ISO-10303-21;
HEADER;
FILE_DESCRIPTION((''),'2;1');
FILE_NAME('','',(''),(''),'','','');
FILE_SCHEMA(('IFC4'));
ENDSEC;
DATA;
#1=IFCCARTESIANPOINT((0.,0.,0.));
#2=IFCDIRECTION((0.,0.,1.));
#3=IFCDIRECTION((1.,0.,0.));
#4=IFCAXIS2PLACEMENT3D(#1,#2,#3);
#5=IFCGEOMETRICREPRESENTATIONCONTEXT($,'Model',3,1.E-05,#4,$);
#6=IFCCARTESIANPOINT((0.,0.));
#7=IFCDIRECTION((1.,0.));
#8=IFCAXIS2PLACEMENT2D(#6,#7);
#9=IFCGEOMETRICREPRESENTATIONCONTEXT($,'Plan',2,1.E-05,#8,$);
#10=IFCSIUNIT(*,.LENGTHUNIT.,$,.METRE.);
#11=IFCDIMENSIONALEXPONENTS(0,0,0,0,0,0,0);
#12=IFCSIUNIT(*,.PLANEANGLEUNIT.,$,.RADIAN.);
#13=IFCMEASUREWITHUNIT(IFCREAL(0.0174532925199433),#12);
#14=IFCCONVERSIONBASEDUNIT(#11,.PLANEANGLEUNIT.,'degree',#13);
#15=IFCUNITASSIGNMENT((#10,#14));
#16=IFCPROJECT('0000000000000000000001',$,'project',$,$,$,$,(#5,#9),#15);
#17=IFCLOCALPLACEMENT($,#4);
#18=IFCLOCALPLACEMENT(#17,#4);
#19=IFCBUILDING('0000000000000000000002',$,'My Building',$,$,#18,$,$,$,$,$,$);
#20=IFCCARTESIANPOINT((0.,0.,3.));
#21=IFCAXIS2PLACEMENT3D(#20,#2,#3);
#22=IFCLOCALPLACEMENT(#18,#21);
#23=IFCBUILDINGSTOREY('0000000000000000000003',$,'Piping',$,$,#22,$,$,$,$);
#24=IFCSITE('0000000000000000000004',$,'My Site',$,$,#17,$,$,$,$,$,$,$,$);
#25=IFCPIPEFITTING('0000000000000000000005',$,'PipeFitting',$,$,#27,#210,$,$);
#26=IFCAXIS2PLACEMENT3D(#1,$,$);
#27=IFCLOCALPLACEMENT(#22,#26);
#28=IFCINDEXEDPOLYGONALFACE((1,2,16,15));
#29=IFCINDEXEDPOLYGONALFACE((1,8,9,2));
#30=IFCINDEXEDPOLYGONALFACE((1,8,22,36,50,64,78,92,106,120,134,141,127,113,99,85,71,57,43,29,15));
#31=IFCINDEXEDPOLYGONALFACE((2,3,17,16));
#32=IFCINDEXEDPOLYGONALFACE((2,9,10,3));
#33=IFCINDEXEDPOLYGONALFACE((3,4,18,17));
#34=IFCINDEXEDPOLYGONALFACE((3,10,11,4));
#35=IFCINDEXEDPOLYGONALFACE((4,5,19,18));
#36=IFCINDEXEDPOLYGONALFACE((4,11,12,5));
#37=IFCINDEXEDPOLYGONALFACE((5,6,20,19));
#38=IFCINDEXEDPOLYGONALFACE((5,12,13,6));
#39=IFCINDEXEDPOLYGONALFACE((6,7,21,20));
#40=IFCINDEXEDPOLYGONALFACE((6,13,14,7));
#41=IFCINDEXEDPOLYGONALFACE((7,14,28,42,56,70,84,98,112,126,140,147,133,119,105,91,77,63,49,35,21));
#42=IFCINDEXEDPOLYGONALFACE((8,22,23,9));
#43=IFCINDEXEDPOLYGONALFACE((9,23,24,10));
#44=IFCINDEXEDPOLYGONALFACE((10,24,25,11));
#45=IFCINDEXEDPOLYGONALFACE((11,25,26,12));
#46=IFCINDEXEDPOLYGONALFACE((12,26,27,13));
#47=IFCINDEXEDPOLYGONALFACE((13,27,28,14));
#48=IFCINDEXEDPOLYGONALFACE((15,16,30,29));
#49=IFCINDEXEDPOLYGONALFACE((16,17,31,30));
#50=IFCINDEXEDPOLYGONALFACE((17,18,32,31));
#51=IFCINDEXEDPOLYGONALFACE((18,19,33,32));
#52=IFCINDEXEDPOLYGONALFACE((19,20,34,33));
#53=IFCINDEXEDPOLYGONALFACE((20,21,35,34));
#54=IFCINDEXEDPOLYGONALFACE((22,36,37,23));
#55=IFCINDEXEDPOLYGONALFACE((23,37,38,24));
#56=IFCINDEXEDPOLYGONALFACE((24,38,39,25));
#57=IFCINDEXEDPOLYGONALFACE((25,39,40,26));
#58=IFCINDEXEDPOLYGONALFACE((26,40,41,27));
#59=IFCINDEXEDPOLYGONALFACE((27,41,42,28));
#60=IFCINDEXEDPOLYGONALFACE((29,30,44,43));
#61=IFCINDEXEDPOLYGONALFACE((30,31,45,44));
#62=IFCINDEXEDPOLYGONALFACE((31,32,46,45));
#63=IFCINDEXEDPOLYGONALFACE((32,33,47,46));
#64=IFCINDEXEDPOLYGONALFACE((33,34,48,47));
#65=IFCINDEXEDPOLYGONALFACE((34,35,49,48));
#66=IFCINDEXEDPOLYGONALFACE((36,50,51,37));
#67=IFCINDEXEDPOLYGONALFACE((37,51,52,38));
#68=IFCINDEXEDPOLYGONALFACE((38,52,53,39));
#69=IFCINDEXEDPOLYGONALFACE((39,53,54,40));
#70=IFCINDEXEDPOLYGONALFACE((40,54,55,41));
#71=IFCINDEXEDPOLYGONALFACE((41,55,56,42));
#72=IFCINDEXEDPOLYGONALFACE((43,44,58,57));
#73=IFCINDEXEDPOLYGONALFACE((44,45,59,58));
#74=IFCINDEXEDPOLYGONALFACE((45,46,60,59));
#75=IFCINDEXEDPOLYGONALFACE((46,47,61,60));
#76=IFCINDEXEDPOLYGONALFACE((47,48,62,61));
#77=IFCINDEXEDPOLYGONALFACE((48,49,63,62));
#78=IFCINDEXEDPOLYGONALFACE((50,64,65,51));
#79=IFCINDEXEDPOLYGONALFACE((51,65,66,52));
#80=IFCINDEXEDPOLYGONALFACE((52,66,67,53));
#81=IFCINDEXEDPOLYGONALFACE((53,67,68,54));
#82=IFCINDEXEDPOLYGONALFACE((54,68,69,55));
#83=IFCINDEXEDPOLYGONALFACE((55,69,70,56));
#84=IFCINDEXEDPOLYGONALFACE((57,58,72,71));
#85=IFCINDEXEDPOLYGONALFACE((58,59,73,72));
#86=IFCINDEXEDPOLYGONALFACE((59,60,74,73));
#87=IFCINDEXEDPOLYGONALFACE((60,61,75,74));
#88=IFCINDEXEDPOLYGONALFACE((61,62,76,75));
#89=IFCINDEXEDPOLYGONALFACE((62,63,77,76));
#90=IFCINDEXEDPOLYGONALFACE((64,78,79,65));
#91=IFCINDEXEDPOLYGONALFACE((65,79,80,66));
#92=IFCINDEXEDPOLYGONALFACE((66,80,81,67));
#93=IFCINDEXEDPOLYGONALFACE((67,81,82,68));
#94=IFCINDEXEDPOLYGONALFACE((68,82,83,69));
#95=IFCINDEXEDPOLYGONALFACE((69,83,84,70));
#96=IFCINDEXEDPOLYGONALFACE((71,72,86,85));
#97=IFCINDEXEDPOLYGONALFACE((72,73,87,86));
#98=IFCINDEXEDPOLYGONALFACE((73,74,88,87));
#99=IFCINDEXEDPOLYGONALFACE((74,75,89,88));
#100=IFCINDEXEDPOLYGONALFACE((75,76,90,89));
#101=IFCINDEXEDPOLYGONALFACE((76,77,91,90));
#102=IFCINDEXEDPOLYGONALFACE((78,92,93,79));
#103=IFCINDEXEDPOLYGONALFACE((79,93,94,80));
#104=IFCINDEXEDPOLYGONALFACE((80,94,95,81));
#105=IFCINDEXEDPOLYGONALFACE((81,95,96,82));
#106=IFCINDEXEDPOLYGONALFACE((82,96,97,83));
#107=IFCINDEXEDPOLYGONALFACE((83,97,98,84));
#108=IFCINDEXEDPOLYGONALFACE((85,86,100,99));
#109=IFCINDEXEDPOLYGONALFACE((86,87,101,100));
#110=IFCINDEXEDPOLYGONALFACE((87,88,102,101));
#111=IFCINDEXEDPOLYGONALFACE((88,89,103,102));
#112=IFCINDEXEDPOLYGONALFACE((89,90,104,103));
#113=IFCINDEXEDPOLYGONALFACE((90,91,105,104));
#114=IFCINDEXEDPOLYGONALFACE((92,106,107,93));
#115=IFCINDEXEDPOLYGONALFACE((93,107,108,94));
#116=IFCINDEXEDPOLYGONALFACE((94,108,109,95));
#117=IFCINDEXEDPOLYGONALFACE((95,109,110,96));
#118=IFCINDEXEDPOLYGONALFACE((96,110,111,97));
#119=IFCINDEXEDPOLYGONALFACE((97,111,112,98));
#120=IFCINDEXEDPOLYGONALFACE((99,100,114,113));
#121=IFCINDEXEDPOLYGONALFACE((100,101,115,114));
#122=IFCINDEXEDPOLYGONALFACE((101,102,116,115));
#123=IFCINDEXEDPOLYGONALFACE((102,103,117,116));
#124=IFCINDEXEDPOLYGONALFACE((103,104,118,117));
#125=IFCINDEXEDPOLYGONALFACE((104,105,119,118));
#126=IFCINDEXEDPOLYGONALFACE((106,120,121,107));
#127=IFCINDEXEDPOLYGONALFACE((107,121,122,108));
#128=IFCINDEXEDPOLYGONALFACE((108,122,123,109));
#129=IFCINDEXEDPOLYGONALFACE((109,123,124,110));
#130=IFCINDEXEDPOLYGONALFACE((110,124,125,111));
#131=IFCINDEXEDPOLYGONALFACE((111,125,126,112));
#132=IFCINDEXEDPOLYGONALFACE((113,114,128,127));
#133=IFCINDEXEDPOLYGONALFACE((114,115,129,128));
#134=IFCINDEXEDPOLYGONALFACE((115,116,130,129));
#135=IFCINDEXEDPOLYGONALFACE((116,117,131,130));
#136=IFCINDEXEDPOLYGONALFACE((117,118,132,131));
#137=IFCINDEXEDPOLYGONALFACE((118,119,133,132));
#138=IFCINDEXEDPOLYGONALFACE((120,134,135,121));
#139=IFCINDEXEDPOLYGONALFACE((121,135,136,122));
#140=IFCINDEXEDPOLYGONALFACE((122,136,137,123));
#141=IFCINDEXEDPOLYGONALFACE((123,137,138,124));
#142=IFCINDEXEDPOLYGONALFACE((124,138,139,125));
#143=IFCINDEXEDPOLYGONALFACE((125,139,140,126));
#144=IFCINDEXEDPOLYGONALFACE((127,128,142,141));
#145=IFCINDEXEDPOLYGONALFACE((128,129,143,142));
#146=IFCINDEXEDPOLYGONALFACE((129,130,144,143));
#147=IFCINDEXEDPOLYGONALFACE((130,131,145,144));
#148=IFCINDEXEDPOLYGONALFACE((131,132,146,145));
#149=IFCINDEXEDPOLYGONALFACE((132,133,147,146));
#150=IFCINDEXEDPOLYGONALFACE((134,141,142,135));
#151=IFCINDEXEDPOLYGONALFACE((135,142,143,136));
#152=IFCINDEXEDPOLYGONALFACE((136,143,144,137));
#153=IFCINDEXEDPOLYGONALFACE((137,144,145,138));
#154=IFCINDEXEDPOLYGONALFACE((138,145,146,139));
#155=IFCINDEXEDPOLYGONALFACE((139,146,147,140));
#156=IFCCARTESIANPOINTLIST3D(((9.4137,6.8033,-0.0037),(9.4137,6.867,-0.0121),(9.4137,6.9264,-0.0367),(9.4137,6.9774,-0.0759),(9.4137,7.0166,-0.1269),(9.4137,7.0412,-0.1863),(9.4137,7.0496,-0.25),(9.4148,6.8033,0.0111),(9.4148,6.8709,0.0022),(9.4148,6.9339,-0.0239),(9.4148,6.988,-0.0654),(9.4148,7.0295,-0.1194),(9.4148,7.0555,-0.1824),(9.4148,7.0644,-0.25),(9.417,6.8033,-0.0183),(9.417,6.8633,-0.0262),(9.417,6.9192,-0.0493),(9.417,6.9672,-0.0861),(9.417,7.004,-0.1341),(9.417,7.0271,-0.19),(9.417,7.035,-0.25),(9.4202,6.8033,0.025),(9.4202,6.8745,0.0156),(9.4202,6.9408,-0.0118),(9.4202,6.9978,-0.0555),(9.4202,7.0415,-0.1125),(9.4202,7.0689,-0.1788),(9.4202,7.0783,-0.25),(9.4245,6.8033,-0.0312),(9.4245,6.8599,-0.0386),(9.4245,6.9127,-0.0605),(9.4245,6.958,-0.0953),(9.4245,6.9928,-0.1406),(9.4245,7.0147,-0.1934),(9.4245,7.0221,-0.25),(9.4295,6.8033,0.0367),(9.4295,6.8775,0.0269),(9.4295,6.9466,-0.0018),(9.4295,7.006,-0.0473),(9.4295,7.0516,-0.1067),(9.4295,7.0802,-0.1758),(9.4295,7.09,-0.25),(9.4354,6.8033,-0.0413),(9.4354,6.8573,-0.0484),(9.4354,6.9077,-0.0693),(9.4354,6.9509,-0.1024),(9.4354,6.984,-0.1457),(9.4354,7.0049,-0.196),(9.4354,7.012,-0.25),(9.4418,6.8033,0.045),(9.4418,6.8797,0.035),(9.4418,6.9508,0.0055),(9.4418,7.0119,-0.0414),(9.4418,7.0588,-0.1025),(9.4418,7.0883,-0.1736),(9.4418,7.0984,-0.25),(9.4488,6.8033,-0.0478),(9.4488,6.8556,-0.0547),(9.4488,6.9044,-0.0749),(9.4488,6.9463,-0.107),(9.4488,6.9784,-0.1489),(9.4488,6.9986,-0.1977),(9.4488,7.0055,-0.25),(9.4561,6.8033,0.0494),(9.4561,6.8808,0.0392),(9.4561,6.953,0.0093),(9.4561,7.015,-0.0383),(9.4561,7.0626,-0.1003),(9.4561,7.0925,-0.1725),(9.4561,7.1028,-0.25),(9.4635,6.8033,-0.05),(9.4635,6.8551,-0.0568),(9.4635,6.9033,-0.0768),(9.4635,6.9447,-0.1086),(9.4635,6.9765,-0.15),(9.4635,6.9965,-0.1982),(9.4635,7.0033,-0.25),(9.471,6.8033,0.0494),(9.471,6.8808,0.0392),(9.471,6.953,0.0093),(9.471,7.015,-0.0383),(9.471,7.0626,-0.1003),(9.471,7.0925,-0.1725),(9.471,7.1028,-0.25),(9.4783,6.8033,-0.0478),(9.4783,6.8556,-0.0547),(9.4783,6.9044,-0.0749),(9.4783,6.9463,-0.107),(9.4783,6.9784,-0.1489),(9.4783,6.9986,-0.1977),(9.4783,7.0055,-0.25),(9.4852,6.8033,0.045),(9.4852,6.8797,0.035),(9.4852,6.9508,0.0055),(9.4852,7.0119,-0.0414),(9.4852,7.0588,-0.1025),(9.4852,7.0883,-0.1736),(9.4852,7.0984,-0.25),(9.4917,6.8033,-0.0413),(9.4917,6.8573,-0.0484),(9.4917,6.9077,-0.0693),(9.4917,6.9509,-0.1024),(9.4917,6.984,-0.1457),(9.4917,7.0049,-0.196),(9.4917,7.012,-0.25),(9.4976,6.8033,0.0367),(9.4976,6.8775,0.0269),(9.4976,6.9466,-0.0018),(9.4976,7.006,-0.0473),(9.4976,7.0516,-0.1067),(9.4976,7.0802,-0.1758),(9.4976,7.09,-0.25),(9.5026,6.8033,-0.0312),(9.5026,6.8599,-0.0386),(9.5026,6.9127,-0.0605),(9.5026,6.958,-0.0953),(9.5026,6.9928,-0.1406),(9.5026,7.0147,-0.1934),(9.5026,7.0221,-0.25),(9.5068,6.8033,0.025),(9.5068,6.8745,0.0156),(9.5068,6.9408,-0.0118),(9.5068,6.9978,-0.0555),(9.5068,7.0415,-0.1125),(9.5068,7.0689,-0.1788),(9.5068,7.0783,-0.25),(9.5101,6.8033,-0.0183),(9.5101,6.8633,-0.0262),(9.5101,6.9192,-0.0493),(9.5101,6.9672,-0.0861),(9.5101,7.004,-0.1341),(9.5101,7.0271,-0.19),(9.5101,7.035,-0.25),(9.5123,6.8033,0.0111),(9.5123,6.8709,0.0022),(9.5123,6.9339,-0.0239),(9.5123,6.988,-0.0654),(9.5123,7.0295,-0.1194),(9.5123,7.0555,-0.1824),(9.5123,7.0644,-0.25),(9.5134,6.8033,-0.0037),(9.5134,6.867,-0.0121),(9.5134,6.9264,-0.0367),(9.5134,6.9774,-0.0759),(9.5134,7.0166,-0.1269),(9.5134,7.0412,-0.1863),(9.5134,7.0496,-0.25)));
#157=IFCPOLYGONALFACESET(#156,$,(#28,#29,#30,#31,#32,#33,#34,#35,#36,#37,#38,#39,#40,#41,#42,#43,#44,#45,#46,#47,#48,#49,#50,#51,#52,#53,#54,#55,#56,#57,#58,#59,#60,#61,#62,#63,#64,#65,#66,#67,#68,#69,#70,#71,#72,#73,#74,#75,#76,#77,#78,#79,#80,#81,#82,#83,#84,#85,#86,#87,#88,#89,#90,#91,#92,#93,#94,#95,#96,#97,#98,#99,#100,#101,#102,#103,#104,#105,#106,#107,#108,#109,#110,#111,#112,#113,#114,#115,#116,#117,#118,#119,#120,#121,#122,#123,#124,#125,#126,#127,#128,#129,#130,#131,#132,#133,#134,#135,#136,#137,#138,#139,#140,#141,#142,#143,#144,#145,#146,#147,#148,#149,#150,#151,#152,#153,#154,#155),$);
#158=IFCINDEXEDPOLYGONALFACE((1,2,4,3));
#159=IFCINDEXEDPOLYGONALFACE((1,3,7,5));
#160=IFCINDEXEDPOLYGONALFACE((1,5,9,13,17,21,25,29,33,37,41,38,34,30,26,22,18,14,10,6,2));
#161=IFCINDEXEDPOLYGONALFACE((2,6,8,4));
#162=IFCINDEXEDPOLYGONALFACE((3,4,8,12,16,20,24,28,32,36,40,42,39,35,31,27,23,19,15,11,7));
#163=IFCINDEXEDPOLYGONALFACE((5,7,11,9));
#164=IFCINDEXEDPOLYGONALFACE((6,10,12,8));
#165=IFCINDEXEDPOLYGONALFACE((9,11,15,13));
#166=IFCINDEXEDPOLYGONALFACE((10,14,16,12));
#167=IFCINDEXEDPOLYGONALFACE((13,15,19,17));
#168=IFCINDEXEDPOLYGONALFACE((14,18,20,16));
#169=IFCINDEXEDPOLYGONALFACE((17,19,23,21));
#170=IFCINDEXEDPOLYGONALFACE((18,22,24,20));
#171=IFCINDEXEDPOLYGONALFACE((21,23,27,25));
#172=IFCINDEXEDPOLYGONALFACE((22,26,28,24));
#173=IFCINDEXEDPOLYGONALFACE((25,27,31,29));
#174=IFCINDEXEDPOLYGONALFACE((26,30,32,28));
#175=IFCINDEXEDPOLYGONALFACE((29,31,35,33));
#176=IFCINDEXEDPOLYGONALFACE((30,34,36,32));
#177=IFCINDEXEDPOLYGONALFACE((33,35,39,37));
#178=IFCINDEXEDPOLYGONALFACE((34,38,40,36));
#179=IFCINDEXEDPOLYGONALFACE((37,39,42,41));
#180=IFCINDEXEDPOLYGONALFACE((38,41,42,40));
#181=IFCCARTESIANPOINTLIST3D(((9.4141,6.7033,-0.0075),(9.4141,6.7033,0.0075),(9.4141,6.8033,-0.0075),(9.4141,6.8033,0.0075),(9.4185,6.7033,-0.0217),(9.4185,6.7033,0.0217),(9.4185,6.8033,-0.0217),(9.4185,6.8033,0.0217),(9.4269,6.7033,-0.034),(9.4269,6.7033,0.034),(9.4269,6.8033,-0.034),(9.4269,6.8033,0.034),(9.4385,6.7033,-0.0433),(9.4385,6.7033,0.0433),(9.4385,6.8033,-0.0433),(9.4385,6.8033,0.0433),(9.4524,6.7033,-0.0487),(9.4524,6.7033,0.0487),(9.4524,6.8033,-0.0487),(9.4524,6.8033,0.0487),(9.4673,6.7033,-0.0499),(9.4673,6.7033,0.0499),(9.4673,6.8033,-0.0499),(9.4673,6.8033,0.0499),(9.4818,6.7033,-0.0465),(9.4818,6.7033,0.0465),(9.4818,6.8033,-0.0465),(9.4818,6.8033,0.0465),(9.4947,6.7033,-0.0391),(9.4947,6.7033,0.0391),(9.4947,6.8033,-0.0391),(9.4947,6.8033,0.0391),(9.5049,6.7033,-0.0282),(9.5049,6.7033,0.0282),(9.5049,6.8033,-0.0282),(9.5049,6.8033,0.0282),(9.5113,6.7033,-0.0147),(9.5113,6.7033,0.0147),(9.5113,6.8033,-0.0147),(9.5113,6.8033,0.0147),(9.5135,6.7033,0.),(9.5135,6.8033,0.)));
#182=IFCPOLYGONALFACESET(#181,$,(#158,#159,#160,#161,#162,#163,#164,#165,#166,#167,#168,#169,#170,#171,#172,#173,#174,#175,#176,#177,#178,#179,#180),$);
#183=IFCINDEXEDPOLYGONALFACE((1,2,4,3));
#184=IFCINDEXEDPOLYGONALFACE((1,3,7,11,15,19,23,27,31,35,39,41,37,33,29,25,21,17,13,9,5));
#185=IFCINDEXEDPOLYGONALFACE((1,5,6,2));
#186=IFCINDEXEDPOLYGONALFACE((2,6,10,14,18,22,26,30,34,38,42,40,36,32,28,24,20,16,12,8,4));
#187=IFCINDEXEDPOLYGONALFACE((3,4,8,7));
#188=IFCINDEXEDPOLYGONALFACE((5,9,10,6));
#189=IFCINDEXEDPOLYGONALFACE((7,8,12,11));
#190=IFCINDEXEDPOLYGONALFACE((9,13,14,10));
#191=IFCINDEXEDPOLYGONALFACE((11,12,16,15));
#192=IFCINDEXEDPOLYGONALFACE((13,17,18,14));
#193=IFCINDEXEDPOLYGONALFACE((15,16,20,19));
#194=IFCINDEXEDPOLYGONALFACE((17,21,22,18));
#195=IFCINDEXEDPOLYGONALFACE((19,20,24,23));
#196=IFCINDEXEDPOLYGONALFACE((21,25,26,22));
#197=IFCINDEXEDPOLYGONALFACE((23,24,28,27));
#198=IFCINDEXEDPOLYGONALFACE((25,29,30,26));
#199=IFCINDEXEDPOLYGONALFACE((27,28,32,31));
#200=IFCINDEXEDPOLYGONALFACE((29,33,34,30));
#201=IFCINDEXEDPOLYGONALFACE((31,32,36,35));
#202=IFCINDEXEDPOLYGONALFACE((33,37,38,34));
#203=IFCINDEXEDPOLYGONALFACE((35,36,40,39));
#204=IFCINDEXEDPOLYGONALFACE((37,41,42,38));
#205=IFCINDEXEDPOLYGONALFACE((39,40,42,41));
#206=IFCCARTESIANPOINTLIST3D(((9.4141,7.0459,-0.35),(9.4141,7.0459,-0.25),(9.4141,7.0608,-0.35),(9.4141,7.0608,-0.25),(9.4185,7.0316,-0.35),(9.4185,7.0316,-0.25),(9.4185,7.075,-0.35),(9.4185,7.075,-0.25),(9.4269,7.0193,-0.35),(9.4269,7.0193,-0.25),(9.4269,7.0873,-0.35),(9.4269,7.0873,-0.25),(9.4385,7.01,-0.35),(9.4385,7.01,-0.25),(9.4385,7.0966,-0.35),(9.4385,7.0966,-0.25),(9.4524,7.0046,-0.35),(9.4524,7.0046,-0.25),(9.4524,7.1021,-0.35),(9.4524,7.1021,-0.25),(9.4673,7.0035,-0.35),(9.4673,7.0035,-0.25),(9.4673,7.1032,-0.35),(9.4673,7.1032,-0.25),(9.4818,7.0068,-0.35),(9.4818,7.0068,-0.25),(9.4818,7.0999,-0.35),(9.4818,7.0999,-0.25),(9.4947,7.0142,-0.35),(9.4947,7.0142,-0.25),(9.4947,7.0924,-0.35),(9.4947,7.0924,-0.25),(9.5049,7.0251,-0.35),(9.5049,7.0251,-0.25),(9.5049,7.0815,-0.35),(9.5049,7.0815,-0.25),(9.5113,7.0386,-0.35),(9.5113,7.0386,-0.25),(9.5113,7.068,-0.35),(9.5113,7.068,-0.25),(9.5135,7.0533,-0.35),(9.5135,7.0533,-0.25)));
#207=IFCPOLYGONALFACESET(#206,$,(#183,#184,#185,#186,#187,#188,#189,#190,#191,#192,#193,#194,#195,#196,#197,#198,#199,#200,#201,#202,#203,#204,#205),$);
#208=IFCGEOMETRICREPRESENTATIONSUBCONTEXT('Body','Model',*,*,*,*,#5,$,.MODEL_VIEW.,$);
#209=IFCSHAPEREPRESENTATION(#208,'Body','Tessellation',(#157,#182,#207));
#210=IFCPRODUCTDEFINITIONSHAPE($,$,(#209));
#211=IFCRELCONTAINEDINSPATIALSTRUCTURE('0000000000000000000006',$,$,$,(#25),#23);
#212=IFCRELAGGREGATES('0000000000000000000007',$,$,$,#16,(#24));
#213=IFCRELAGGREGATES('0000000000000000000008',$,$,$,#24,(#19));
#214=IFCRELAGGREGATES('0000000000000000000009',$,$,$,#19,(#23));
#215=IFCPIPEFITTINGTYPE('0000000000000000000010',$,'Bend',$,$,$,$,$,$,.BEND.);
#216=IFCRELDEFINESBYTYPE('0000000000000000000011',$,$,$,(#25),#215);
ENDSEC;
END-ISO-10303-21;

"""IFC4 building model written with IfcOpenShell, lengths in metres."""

from ifc_helpers import new_model, entity, si_unit, converted_unit, frame, origin_with_axes, origin_2d_with_axis, place, context, subcontext, project, spatial, circle, extrude, source, transform, mapped, type_object, type_shapes, element, save


model = new_model("IFC4")

# Units and contexts
model_context = context("Model", 3, precision=1e-05, world=origin_with_axes())
plan_context = context("Plan", 2, precision=1e-05, world=origin_2d_with_axis())
body_context = subcontext(model_context, "Body", "Model", "MODEL_VIEW")
ifc_project = project(units=[si_unit("LENGTHUNIT", "METRE"), converted_unit("PLANEANGLEUNIT", "degree", entity("IfcReal", 0.0174532925199433), si_unit("PLANEANGLEUNIT", "RADIAN"), dimensions=[0, 0, 0, 0, 0, 0, 0])], contexts=[model_context, plan_context])

# Site, building, storey
site_placement = place(None, origin_with_axes())
site = spatial("IfcSite", under=ifc_project, at=site_placement, Name="My Site")
building_placement = place(site_placement, origin_with_axes())
building = spatial("IfcBuilding", under=site, at=building_placement, Name="My Building")
storey_placement = place(building_placement, frame((0.0, 0.0, 3.0), z_axis=(0.0, 0.0, 1.0), x_axis=(1.0, 0.0, 0.0)))
storey = spatial("IfcBuildingStorey", under=building, at=storey_placement, Name="Piping")

# Shared definitions
pipe_fitting_type = type_object("IfcPipeFittingType", Name="Bend", PredefinedType="BEND")
shared_shape = source(origin_with_axes(), body_context, "Body", "SolidModel", [
    entity("IfcSweptDiskSolid", entity("IfcIndexedPolyCurve", entity("IfcCartesianPointList3D", [[0.0, 0.0, -0.1], [0.0, -0.0732, -0.2768], [0.0, -0.25, -0.35]]), [entity("IfcArcIndex", [1, 2, 3])]), 0.05),
    extrude(circle(Radius=0.05), origin_with_axes(), (0.0, 0.0, -1.0), 0.1),
    extrude(circle(Radius=0.05), frame((0.0, -0.25, -0.35), z_axis=(0.0, -1.0, 0.0), x_axis=(1.0, 0.0, 0.0)), (0.0, 0.0, 1.0), 0.1),
])
type_shapes(pipe_fitting_type, [shared_shape])

# Pipe fitting
for number, where, z_axis, x_axis, name in (
    (1, (9.4635, 6.7033, 0.0), (0.0, -1.0, 0.0), (1.0, 0.0, 0.0), "PipeFitting"),
):
    element("IfcPipeFitting", number, at=place(storey_placement, frame(where, z_axis=z_axis, x_axis=x_axis)), inside=storey, type_object=pipe_fitting_type, Name=name, context=body_context, shape_type="MappedRepresentation", body=[
        mapped(shared_shape, transform((0.0, 0.0, 0.0), x_axis=(1.0, 0.0, 0.0), y_axis=(0.0, 1.0, 0.0), z_axis=(0.0, 0.0, 1.0), scale=1.0)),
    ])

save(model, "model.ifc")
